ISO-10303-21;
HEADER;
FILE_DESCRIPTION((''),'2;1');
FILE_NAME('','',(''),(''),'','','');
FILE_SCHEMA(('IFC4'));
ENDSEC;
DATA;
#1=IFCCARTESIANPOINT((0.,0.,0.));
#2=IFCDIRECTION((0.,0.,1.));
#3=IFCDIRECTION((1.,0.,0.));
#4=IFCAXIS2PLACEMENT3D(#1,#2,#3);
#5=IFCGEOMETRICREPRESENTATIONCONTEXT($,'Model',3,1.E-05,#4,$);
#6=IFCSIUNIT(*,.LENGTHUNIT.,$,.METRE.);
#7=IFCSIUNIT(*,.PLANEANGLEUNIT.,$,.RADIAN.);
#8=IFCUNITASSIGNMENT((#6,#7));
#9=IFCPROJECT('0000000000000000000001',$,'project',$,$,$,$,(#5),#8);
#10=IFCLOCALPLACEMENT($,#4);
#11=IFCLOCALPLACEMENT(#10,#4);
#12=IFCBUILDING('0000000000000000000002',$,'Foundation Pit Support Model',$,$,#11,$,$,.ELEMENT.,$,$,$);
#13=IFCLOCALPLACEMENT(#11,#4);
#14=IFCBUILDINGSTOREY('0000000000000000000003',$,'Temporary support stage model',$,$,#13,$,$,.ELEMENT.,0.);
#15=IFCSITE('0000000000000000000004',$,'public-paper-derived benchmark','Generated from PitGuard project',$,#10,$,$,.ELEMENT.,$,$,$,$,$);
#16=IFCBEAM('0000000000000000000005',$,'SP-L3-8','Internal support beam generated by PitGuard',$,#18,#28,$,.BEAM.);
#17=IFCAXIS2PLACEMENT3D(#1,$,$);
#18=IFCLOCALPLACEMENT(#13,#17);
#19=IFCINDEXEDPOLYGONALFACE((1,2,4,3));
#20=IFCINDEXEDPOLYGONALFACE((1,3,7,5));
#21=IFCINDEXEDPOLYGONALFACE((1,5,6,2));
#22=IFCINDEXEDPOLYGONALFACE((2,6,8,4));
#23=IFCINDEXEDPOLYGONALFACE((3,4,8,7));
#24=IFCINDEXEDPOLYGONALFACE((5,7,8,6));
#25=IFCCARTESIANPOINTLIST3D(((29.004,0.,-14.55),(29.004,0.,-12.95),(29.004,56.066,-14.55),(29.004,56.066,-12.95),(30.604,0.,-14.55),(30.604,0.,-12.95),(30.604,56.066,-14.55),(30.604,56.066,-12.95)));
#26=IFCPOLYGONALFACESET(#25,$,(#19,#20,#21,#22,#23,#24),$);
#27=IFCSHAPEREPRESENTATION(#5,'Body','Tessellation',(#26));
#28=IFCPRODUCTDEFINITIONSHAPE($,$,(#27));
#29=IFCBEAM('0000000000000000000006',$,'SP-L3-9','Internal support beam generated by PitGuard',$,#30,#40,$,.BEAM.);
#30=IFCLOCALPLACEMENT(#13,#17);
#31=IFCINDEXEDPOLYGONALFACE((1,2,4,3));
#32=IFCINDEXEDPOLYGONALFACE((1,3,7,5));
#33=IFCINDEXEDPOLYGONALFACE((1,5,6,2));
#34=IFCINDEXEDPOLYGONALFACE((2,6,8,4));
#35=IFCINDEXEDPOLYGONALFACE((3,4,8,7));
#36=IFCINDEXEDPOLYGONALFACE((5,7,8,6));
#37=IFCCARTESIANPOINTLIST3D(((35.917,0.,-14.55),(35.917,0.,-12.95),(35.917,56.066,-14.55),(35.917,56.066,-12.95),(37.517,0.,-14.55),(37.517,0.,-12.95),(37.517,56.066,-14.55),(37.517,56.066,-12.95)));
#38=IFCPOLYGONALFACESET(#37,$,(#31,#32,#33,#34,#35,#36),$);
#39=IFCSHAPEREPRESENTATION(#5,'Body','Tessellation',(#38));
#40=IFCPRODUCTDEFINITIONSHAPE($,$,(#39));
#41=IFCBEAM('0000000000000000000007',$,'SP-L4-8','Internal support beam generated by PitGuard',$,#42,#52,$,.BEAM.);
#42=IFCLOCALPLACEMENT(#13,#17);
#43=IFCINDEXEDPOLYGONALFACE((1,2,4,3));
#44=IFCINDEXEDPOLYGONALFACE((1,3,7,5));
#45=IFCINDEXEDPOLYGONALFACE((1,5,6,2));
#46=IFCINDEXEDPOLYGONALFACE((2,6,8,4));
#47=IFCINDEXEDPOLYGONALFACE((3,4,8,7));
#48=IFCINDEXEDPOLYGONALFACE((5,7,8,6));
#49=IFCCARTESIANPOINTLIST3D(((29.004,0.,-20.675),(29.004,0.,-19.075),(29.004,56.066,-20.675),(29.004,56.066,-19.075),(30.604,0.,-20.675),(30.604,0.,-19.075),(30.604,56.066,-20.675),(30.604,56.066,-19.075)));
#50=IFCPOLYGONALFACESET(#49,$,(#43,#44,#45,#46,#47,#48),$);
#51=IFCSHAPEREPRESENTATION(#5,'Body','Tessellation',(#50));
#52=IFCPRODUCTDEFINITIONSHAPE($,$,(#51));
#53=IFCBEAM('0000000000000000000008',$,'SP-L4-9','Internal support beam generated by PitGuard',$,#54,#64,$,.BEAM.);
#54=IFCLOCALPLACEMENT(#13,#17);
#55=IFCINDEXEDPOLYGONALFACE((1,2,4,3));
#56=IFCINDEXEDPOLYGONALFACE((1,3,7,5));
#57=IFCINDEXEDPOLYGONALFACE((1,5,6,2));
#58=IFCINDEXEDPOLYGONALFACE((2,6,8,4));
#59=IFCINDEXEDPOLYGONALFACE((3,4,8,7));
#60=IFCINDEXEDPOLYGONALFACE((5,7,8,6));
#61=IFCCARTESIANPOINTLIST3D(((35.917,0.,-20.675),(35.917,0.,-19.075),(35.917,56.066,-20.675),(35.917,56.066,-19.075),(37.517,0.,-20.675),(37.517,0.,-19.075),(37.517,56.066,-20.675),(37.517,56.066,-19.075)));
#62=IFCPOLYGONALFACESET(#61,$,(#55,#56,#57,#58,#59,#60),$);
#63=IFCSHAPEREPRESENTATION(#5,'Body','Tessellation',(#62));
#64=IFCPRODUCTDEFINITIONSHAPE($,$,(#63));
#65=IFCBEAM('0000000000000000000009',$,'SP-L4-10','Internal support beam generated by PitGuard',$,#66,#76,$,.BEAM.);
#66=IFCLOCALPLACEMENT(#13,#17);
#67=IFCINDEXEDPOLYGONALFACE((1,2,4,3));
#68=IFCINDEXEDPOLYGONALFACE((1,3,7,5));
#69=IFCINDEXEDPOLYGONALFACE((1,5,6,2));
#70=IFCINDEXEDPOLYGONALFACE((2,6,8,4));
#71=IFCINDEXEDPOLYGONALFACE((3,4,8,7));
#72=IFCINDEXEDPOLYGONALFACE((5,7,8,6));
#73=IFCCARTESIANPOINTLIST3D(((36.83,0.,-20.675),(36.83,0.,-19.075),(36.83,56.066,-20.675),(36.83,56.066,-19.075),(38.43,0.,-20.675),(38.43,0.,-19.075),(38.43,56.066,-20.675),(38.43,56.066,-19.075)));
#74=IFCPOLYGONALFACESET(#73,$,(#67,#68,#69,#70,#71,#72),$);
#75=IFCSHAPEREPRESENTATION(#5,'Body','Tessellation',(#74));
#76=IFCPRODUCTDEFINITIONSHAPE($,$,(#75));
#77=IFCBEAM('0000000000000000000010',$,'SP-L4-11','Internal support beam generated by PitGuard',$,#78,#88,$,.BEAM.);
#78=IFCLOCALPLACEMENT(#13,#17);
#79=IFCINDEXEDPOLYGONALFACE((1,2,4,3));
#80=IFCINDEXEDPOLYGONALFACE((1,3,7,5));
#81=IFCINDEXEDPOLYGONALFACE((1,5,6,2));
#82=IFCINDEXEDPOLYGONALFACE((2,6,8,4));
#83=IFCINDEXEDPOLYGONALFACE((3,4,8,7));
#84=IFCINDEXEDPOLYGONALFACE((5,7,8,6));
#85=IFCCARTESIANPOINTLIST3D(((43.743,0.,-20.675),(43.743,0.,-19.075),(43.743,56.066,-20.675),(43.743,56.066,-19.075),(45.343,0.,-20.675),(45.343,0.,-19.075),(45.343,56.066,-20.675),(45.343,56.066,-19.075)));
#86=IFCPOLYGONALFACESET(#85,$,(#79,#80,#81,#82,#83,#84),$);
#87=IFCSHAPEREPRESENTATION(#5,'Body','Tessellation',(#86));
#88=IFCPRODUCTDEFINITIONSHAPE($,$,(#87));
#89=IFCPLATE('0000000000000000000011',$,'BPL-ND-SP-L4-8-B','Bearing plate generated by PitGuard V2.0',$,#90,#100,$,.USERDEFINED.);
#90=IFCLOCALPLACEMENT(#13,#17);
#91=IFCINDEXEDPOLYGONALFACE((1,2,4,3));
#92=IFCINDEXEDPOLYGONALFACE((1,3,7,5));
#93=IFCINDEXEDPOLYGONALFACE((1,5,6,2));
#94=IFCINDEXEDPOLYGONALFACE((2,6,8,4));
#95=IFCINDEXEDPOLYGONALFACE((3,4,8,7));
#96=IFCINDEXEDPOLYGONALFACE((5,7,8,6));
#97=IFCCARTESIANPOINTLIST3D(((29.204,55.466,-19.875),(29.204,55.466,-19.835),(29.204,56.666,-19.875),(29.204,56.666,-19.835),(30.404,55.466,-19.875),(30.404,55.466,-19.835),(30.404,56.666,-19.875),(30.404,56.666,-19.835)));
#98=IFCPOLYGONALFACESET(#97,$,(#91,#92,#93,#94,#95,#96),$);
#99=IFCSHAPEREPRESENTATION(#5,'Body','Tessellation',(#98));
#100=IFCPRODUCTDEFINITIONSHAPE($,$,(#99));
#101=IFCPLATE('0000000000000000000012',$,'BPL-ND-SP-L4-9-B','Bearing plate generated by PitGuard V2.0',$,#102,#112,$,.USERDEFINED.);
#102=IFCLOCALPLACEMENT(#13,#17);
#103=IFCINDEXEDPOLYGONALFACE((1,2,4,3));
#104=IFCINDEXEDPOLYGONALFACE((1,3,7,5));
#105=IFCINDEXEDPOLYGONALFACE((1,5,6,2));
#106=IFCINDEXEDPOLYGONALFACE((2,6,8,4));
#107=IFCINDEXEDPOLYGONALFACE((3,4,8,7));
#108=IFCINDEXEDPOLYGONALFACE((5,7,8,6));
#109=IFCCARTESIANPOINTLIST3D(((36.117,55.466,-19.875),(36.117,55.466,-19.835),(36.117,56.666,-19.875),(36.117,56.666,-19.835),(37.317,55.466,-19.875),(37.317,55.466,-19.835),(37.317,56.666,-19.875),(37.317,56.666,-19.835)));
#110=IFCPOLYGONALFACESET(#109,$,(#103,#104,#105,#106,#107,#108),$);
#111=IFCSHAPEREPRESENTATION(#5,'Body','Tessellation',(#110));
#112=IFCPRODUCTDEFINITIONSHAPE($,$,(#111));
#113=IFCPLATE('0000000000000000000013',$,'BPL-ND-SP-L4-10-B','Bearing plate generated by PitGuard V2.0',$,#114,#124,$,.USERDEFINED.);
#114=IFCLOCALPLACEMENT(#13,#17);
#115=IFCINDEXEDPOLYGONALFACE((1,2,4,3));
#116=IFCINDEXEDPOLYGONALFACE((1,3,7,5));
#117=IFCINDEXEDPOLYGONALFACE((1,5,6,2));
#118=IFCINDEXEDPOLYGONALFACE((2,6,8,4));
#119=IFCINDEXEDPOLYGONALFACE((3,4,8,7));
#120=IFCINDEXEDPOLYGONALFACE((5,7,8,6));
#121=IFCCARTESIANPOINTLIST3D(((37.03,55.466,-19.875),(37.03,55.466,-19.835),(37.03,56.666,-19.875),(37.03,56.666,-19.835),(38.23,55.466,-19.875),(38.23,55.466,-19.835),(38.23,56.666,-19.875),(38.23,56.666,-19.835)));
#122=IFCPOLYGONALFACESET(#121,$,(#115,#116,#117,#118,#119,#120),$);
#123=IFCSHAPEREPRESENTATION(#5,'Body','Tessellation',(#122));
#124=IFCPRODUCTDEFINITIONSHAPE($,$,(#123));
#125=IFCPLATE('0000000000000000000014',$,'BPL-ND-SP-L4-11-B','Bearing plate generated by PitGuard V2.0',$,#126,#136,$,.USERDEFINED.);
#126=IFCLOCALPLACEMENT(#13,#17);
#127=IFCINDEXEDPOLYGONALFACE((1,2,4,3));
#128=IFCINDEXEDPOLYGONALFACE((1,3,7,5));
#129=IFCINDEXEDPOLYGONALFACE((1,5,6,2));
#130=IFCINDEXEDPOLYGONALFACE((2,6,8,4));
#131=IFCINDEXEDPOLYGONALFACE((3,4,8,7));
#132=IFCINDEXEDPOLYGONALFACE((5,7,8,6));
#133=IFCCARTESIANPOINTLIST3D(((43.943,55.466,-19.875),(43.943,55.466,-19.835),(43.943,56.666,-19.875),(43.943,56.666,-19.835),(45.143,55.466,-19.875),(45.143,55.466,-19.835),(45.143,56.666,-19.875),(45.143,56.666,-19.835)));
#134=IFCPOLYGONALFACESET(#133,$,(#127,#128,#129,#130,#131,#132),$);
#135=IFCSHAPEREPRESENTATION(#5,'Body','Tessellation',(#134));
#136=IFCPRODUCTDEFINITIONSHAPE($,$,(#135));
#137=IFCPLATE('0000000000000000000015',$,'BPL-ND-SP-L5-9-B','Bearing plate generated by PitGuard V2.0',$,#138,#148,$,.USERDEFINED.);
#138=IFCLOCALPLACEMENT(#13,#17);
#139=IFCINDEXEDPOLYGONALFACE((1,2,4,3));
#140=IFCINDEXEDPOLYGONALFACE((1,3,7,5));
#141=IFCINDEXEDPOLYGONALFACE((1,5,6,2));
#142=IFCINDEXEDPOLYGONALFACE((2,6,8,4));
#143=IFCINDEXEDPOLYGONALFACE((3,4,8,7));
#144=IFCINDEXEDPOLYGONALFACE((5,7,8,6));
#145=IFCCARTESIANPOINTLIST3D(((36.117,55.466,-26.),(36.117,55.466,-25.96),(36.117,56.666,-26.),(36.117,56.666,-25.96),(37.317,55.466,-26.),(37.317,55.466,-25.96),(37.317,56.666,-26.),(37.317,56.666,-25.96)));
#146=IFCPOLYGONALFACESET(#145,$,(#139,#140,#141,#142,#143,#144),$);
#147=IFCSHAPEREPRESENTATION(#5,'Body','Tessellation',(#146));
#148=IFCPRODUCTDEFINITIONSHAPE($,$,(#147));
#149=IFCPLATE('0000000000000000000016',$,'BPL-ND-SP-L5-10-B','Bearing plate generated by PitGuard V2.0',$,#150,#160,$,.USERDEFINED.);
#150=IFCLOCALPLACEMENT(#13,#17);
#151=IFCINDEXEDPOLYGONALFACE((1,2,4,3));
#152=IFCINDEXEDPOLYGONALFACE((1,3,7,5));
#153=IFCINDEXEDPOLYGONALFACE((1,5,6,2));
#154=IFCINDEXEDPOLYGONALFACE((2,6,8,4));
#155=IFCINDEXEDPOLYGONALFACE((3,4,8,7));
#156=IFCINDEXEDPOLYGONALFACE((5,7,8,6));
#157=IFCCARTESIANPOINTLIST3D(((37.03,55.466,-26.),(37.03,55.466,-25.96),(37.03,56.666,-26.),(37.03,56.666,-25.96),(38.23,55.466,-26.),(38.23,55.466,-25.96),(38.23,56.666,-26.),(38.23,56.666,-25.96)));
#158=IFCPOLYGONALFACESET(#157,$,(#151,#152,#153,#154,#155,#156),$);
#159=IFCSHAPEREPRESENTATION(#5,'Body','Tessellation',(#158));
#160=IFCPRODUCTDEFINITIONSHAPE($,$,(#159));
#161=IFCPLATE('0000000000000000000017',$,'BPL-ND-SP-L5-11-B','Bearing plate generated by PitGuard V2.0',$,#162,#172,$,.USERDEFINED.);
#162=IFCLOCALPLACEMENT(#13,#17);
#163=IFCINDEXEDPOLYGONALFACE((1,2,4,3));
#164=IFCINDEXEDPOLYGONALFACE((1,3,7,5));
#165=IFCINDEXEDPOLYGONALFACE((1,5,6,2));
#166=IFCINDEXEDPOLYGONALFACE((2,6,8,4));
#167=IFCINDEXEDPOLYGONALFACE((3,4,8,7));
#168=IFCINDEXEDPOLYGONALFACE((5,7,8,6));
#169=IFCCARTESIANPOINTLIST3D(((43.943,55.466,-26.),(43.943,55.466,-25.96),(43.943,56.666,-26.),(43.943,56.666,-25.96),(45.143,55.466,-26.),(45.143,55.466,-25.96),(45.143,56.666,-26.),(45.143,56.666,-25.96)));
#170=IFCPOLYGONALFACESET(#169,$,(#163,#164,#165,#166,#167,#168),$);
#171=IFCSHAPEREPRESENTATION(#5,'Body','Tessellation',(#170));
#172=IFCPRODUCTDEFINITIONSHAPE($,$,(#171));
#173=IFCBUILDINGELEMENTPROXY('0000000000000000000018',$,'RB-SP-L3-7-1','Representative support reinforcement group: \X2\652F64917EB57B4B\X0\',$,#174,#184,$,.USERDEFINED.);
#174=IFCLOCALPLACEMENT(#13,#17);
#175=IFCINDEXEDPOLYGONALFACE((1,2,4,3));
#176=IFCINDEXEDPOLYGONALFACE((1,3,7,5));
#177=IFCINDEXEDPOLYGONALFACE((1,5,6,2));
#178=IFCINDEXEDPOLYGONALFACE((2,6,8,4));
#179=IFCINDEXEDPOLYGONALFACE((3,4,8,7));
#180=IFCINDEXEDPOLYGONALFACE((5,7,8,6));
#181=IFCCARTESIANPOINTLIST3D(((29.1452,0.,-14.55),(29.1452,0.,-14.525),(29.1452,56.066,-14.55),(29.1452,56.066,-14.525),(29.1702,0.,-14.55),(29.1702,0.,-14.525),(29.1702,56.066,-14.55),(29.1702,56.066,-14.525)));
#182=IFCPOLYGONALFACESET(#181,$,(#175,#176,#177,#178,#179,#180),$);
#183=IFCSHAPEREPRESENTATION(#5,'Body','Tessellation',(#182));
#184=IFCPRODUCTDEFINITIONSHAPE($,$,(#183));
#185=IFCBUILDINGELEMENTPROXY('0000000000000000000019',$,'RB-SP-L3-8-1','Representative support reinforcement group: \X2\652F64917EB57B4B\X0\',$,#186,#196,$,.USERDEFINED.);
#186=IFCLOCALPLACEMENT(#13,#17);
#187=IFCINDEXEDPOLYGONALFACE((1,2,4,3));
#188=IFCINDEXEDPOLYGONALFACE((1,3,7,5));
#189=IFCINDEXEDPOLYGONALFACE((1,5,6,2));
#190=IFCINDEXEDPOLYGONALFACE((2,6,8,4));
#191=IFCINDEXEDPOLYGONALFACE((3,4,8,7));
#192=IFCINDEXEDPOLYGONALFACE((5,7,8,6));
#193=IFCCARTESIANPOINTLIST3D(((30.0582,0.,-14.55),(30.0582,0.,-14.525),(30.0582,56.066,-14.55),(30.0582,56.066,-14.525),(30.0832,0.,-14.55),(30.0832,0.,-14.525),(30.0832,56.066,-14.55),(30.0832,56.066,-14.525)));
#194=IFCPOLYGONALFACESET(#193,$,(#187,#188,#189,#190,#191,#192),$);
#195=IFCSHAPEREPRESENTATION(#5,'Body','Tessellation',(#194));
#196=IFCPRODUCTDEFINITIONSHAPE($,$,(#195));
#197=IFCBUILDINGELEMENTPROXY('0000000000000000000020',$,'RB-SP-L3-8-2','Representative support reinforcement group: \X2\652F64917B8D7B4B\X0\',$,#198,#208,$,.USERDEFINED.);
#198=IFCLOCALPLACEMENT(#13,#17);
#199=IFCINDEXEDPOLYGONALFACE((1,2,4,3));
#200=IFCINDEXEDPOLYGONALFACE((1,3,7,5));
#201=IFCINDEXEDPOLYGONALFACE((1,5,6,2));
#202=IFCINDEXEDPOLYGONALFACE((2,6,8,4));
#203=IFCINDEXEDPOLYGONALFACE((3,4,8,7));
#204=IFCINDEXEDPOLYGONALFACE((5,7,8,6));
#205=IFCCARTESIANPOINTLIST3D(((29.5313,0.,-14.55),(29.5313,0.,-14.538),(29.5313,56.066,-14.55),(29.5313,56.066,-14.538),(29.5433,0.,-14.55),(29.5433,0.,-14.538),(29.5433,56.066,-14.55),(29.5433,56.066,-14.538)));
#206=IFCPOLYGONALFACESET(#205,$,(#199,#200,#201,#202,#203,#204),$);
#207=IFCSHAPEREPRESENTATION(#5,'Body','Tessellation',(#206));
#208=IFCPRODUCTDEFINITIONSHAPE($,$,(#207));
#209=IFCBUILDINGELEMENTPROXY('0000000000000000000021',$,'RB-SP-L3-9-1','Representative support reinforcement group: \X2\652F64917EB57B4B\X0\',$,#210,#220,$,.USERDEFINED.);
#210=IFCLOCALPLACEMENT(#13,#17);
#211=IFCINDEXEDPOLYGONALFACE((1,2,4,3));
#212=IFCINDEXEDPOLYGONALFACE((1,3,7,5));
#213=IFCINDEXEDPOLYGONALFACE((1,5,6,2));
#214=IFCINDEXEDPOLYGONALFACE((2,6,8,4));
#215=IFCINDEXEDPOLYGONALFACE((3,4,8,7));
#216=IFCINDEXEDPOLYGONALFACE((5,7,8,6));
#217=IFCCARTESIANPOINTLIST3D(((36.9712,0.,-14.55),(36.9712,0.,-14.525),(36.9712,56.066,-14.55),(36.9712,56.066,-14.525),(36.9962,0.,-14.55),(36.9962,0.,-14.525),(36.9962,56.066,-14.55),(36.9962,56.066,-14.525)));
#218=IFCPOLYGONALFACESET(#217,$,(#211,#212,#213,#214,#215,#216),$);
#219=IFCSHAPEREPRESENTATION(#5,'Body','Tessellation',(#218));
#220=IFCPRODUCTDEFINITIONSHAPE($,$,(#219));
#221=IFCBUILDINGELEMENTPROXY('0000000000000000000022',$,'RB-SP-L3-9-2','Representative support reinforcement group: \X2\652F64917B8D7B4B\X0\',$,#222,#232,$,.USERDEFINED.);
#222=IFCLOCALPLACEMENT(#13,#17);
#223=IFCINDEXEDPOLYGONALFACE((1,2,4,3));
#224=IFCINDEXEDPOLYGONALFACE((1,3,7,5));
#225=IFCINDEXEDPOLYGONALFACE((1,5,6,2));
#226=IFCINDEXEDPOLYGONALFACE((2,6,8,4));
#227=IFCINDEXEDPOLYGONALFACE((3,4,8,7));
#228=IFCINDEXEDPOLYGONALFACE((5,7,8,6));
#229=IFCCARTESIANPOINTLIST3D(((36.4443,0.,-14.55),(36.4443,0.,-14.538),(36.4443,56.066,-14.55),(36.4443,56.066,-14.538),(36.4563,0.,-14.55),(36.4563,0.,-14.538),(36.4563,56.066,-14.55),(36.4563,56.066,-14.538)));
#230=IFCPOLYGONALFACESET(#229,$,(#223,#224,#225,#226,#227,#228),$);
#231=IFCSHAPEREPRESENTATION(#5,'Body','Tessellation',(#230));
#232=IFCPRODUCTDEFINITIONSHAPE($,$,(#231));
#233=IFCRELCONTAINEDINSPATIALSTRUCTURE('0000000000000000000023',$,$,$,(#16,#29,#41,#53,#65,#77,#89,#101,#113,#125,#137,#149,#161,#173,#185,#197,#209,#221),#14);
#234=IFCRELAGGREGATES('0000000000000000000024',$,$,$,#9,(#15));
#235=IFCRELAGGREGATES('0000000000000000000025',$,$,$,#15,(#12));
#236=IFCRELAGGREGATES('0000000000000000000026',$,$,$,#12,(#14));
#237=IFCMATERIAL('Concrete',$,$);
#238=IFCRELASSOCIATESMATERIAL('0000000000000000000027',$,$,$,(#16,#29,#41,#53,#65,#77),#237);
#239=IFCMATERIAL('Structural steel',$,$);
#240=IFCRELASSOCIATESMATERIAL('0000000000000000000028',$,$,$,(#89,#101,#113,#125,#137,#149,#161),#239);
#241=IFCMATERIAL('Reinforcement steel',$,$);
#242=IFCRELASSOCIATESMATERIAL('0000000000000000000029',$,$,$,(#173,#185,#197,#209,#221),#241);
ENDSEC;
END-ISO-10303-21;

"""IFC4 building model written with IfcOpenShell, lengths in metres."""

from ifc_helpers import new_model, si_unit, frame, origin_with_axes, origin_2d, place, context, project, spatial, rectangle, extrude, material, element, save


model = new_model("IFC4")

# Units and contexts
model_context = context("Model", 3, precision=1e-05, world=origin_with_axes())
ifc_project = project(units=[si_unit("LENGTHUNIT", "METRE"), si_unit("PLANEANGLEUNIT", "RADIAN")], contexts=[model_context])

# Site, building, storey
site_placement = place(None, origin_with_axes())
site = spatial("IfcSite", under=ifc_project, at=site_placement, Name="public-paper-derived benchmark", Description="Generated from PitGuard project", CompositionType="ELEMENT")
building_placement = place(site_placement, origin_with_axes())
building = spatial("IfcBuilding", under=site, at=building_placement, Name="Foundation Pit Support Model", CompositionType="ELEMENT")
storey_placement = place(building_placement, origin_with_axes())
storey = spatial("IfcBuildingStorey", under=building, at=storey_placement, Name="Temporary support stage model", CompositionType="ELEMENT", Elevation=0.0)

# Beams
ifc_material_1 = material(Name="Concrete")
for number, where, z_axis, x_axis, name in (
    (1, (29.804, 28.033, -14.55), (0.0, 0.0, 1.0), (0.0, 1.0, 0.0), "SP-L3-8"),
    (2, (36.717, 28.033, -14.55), (0.0, 0.0, 1.0), (0.0, 1.0, 0.0), "SP-L3-9"),
    (3, (29.804, 28.033, -20.675), (0.0, 0.0, 1.0), (0.0, 1.0, 0.0), "SP-L4-8"),
    (4, (36.717, 28.033, -20.675), (0.0, 0.0, 1.0), (0.0, 1.0, 0.0), "SP-L4-9"),
    (5, (37.63, 28.033, -20.675), (0.0, 0.0, 1.0), (0.0, 1.0, 0.0), "SP-L4-10"),
    (6, (44.543, 28.033, -20.675), (0.0, 0.0, 1.0), (0.0, 1.0, 0.0), "SP-L4-11"),
):
    element("IfcBeam", number, at=place(storey_placement, frame(where, z_axis=z_axis, x_axis=x_axis)), inside=storey, material=ifc_material_1, Name=name, Description="Internal support beam generated by PitGuard", PredefinedType="BEAM", context=model_context, shape_type="SweptSolid", body=[
        extrude(rectangle(XDim=56.066, YDim=1.6, at=origin_2d()), origin_with_axes(), (0.0, 0.0, 1.0), 1.6),
    ])

# Plates
ifc_material_2 = material(Name="Structural steel")
for number, where, z_axis, x_axis, name in (
    (7, (29.804, 56.066, -19.875), (0.0, 0.0, 1.0), (1.0, 0.0, 0.0), "BPL-ND-SP-L4-8-B"),
    (8, (36.717, 56.066, -19.875), (0.0, 0.0, 1.0), (1.0, 0.0, 0.0), "BPL-ND-SP-L4-9-B"),
    (9, (37.63, 56.066, -19.875), (0.0, 0.0, 1.0), (1.0, 0.0, 0.0), "BPL-ND-SP-L4-10-B"),
    (10, (44.543, 56.066, -19.875), (0.0, 0.0, 1.0), (1.0, 0.0, 0.0), "BPL-ND-SP-L4-11-B"),
    (11, (36.717, 56.066, -26.0), (0.0, 0.0, 1.0), (1.0, 0.0, 0.0), "BPL-ND-SP-L5-9-B"),
    (12, (37.63, 56.066, -26.0), (0.0, 0.0, 1.0), (1.0, 0.0, 0.0), "BPL-ND-SP-L5-10-B"),
    (13, (44.543, 56.066, -26.0), (0.0, 0.0, 1.0), (1.0, 0.0, 0.0), "BPL-ND-SP-L5-11-B"),
):
    element("IfcPlate", number, at=place(storey_placement, frame(where, z_axis=z_axis, x_axis=x_axis)), inside=storey, material=ifc_material_2, Name=name, Description="Bearing plate generated by PitGuard V2.0", PredefinedType="USERDEFINED", context=model_context, shape_type="SweptSolid", body=[
        extrude(rectangle(XDim=1.2, YDim=1.2, at=origin_2d()), origin_with_axes(), (0.0, 0.0, 1.0), 0.04),
    ])

# Building element proxies
ifc_material_3 = material(Name="Reinforcement steel")
for number, where, z_axis, x_axis, name in (
    (14, (29.1577, 28.033, -14.55), (0.0, 0.0, 1.0), (0.0, 1.0, 0.0), "RB-SP-L3-7-1"),
    (15, (30.0707, 28.033, -14.55), (0.0, 0.0, 1.0), (0.0, 1.0, 0.0), "RB-SP-L3-8-1"),
):
    element("IfcBuildingElementProxy", number, at=place(storey_placement, frame(where, z_axis=z_axis, x_axis=x_axis)), inside=storey, material=ifc_material_3, Name=name, Description="Representative support reinforcement group: 支撑纵筋", PredefinedType="USERDEFINED", context=model_context, shape_type="SweptSolid", body=[
        extrude(rectangle(XDim=56.066, YDim=0.025, at=origin_2d()), origin_with_axes(), (0.0, 0.0, 1.0), 0.025),
    ])
proxy_1_placement = place(storey_placement, frame((29.5373, 28.033, -14.55), z_axis=(0.0, 0.0, 1.0), x_axis=(0.0, 1.0, 0.0)))
element("IfcBuildingElementProxy", 16, at=proxy_1_placement, inside=storey, material=ifc_material_3, Name="RB-SP-L3-8-2", Description="Representative support reinforcement group: 支撑箍筋", PredefinedType="USERDEFINED", context=model_context, shape_type="SweptSolid", body=[
    extrude(rectangle(XDim=56.066, YDim=0.012, at=origin_2d()), origin_with_axes(), (0.0, 0.0, 1.0), 0.012),
])
proxy_2_placement = place(storey_placement, frame((36.9837, 28.033, -14.55), z_axis=(0.0, 0.0, 1.0), x_axis=(0.0, 1.0, 0.0)))
element("IfcBuildingElementProxy", 17, at=proxy_2_placement, inside=storey, material=ifc_material_3, Name="RB-SP-L3-9-1", Description="Representative support reinforcement group: 支撑纵筋", PredefinedType="USERDEFINED", context=model_context, shape_type="SweptSolid", body=[
    extrude(rectangle(XDim=56.066, YDim=0.025, at=origin_2d()), origin_with_axes(), (0.0, 0.0, 1.0), 0.025),
])
for number, where, z_axis, x_axis, name in (
    (18, (36.4503, 28.033, -14.55), (0.0, 0.0, 1.0), (0.0, 1.0, 0.0), "RB-SP-L3-9-2"),
):
    element("IfcBuildingElementProxy", number, at=place(storey_placement, frame(where, z_axis=z_axis, x_axis=x_axis)), inside=storey, material=ifc_material_3, Name=name, Description="Representative support reinforcement group: 支撑箍筋", PredefinedType="USERDEFINED", context=model_context, shape_type="SweptSolid", body=[
        extrude(rectangle(XDim=56.066, YDim=0.012, at=origin_2d()), origin_with_axes(), (0.0, 0.0, 1.0), 0.012),
    ])

save(model, "model.ifc")
